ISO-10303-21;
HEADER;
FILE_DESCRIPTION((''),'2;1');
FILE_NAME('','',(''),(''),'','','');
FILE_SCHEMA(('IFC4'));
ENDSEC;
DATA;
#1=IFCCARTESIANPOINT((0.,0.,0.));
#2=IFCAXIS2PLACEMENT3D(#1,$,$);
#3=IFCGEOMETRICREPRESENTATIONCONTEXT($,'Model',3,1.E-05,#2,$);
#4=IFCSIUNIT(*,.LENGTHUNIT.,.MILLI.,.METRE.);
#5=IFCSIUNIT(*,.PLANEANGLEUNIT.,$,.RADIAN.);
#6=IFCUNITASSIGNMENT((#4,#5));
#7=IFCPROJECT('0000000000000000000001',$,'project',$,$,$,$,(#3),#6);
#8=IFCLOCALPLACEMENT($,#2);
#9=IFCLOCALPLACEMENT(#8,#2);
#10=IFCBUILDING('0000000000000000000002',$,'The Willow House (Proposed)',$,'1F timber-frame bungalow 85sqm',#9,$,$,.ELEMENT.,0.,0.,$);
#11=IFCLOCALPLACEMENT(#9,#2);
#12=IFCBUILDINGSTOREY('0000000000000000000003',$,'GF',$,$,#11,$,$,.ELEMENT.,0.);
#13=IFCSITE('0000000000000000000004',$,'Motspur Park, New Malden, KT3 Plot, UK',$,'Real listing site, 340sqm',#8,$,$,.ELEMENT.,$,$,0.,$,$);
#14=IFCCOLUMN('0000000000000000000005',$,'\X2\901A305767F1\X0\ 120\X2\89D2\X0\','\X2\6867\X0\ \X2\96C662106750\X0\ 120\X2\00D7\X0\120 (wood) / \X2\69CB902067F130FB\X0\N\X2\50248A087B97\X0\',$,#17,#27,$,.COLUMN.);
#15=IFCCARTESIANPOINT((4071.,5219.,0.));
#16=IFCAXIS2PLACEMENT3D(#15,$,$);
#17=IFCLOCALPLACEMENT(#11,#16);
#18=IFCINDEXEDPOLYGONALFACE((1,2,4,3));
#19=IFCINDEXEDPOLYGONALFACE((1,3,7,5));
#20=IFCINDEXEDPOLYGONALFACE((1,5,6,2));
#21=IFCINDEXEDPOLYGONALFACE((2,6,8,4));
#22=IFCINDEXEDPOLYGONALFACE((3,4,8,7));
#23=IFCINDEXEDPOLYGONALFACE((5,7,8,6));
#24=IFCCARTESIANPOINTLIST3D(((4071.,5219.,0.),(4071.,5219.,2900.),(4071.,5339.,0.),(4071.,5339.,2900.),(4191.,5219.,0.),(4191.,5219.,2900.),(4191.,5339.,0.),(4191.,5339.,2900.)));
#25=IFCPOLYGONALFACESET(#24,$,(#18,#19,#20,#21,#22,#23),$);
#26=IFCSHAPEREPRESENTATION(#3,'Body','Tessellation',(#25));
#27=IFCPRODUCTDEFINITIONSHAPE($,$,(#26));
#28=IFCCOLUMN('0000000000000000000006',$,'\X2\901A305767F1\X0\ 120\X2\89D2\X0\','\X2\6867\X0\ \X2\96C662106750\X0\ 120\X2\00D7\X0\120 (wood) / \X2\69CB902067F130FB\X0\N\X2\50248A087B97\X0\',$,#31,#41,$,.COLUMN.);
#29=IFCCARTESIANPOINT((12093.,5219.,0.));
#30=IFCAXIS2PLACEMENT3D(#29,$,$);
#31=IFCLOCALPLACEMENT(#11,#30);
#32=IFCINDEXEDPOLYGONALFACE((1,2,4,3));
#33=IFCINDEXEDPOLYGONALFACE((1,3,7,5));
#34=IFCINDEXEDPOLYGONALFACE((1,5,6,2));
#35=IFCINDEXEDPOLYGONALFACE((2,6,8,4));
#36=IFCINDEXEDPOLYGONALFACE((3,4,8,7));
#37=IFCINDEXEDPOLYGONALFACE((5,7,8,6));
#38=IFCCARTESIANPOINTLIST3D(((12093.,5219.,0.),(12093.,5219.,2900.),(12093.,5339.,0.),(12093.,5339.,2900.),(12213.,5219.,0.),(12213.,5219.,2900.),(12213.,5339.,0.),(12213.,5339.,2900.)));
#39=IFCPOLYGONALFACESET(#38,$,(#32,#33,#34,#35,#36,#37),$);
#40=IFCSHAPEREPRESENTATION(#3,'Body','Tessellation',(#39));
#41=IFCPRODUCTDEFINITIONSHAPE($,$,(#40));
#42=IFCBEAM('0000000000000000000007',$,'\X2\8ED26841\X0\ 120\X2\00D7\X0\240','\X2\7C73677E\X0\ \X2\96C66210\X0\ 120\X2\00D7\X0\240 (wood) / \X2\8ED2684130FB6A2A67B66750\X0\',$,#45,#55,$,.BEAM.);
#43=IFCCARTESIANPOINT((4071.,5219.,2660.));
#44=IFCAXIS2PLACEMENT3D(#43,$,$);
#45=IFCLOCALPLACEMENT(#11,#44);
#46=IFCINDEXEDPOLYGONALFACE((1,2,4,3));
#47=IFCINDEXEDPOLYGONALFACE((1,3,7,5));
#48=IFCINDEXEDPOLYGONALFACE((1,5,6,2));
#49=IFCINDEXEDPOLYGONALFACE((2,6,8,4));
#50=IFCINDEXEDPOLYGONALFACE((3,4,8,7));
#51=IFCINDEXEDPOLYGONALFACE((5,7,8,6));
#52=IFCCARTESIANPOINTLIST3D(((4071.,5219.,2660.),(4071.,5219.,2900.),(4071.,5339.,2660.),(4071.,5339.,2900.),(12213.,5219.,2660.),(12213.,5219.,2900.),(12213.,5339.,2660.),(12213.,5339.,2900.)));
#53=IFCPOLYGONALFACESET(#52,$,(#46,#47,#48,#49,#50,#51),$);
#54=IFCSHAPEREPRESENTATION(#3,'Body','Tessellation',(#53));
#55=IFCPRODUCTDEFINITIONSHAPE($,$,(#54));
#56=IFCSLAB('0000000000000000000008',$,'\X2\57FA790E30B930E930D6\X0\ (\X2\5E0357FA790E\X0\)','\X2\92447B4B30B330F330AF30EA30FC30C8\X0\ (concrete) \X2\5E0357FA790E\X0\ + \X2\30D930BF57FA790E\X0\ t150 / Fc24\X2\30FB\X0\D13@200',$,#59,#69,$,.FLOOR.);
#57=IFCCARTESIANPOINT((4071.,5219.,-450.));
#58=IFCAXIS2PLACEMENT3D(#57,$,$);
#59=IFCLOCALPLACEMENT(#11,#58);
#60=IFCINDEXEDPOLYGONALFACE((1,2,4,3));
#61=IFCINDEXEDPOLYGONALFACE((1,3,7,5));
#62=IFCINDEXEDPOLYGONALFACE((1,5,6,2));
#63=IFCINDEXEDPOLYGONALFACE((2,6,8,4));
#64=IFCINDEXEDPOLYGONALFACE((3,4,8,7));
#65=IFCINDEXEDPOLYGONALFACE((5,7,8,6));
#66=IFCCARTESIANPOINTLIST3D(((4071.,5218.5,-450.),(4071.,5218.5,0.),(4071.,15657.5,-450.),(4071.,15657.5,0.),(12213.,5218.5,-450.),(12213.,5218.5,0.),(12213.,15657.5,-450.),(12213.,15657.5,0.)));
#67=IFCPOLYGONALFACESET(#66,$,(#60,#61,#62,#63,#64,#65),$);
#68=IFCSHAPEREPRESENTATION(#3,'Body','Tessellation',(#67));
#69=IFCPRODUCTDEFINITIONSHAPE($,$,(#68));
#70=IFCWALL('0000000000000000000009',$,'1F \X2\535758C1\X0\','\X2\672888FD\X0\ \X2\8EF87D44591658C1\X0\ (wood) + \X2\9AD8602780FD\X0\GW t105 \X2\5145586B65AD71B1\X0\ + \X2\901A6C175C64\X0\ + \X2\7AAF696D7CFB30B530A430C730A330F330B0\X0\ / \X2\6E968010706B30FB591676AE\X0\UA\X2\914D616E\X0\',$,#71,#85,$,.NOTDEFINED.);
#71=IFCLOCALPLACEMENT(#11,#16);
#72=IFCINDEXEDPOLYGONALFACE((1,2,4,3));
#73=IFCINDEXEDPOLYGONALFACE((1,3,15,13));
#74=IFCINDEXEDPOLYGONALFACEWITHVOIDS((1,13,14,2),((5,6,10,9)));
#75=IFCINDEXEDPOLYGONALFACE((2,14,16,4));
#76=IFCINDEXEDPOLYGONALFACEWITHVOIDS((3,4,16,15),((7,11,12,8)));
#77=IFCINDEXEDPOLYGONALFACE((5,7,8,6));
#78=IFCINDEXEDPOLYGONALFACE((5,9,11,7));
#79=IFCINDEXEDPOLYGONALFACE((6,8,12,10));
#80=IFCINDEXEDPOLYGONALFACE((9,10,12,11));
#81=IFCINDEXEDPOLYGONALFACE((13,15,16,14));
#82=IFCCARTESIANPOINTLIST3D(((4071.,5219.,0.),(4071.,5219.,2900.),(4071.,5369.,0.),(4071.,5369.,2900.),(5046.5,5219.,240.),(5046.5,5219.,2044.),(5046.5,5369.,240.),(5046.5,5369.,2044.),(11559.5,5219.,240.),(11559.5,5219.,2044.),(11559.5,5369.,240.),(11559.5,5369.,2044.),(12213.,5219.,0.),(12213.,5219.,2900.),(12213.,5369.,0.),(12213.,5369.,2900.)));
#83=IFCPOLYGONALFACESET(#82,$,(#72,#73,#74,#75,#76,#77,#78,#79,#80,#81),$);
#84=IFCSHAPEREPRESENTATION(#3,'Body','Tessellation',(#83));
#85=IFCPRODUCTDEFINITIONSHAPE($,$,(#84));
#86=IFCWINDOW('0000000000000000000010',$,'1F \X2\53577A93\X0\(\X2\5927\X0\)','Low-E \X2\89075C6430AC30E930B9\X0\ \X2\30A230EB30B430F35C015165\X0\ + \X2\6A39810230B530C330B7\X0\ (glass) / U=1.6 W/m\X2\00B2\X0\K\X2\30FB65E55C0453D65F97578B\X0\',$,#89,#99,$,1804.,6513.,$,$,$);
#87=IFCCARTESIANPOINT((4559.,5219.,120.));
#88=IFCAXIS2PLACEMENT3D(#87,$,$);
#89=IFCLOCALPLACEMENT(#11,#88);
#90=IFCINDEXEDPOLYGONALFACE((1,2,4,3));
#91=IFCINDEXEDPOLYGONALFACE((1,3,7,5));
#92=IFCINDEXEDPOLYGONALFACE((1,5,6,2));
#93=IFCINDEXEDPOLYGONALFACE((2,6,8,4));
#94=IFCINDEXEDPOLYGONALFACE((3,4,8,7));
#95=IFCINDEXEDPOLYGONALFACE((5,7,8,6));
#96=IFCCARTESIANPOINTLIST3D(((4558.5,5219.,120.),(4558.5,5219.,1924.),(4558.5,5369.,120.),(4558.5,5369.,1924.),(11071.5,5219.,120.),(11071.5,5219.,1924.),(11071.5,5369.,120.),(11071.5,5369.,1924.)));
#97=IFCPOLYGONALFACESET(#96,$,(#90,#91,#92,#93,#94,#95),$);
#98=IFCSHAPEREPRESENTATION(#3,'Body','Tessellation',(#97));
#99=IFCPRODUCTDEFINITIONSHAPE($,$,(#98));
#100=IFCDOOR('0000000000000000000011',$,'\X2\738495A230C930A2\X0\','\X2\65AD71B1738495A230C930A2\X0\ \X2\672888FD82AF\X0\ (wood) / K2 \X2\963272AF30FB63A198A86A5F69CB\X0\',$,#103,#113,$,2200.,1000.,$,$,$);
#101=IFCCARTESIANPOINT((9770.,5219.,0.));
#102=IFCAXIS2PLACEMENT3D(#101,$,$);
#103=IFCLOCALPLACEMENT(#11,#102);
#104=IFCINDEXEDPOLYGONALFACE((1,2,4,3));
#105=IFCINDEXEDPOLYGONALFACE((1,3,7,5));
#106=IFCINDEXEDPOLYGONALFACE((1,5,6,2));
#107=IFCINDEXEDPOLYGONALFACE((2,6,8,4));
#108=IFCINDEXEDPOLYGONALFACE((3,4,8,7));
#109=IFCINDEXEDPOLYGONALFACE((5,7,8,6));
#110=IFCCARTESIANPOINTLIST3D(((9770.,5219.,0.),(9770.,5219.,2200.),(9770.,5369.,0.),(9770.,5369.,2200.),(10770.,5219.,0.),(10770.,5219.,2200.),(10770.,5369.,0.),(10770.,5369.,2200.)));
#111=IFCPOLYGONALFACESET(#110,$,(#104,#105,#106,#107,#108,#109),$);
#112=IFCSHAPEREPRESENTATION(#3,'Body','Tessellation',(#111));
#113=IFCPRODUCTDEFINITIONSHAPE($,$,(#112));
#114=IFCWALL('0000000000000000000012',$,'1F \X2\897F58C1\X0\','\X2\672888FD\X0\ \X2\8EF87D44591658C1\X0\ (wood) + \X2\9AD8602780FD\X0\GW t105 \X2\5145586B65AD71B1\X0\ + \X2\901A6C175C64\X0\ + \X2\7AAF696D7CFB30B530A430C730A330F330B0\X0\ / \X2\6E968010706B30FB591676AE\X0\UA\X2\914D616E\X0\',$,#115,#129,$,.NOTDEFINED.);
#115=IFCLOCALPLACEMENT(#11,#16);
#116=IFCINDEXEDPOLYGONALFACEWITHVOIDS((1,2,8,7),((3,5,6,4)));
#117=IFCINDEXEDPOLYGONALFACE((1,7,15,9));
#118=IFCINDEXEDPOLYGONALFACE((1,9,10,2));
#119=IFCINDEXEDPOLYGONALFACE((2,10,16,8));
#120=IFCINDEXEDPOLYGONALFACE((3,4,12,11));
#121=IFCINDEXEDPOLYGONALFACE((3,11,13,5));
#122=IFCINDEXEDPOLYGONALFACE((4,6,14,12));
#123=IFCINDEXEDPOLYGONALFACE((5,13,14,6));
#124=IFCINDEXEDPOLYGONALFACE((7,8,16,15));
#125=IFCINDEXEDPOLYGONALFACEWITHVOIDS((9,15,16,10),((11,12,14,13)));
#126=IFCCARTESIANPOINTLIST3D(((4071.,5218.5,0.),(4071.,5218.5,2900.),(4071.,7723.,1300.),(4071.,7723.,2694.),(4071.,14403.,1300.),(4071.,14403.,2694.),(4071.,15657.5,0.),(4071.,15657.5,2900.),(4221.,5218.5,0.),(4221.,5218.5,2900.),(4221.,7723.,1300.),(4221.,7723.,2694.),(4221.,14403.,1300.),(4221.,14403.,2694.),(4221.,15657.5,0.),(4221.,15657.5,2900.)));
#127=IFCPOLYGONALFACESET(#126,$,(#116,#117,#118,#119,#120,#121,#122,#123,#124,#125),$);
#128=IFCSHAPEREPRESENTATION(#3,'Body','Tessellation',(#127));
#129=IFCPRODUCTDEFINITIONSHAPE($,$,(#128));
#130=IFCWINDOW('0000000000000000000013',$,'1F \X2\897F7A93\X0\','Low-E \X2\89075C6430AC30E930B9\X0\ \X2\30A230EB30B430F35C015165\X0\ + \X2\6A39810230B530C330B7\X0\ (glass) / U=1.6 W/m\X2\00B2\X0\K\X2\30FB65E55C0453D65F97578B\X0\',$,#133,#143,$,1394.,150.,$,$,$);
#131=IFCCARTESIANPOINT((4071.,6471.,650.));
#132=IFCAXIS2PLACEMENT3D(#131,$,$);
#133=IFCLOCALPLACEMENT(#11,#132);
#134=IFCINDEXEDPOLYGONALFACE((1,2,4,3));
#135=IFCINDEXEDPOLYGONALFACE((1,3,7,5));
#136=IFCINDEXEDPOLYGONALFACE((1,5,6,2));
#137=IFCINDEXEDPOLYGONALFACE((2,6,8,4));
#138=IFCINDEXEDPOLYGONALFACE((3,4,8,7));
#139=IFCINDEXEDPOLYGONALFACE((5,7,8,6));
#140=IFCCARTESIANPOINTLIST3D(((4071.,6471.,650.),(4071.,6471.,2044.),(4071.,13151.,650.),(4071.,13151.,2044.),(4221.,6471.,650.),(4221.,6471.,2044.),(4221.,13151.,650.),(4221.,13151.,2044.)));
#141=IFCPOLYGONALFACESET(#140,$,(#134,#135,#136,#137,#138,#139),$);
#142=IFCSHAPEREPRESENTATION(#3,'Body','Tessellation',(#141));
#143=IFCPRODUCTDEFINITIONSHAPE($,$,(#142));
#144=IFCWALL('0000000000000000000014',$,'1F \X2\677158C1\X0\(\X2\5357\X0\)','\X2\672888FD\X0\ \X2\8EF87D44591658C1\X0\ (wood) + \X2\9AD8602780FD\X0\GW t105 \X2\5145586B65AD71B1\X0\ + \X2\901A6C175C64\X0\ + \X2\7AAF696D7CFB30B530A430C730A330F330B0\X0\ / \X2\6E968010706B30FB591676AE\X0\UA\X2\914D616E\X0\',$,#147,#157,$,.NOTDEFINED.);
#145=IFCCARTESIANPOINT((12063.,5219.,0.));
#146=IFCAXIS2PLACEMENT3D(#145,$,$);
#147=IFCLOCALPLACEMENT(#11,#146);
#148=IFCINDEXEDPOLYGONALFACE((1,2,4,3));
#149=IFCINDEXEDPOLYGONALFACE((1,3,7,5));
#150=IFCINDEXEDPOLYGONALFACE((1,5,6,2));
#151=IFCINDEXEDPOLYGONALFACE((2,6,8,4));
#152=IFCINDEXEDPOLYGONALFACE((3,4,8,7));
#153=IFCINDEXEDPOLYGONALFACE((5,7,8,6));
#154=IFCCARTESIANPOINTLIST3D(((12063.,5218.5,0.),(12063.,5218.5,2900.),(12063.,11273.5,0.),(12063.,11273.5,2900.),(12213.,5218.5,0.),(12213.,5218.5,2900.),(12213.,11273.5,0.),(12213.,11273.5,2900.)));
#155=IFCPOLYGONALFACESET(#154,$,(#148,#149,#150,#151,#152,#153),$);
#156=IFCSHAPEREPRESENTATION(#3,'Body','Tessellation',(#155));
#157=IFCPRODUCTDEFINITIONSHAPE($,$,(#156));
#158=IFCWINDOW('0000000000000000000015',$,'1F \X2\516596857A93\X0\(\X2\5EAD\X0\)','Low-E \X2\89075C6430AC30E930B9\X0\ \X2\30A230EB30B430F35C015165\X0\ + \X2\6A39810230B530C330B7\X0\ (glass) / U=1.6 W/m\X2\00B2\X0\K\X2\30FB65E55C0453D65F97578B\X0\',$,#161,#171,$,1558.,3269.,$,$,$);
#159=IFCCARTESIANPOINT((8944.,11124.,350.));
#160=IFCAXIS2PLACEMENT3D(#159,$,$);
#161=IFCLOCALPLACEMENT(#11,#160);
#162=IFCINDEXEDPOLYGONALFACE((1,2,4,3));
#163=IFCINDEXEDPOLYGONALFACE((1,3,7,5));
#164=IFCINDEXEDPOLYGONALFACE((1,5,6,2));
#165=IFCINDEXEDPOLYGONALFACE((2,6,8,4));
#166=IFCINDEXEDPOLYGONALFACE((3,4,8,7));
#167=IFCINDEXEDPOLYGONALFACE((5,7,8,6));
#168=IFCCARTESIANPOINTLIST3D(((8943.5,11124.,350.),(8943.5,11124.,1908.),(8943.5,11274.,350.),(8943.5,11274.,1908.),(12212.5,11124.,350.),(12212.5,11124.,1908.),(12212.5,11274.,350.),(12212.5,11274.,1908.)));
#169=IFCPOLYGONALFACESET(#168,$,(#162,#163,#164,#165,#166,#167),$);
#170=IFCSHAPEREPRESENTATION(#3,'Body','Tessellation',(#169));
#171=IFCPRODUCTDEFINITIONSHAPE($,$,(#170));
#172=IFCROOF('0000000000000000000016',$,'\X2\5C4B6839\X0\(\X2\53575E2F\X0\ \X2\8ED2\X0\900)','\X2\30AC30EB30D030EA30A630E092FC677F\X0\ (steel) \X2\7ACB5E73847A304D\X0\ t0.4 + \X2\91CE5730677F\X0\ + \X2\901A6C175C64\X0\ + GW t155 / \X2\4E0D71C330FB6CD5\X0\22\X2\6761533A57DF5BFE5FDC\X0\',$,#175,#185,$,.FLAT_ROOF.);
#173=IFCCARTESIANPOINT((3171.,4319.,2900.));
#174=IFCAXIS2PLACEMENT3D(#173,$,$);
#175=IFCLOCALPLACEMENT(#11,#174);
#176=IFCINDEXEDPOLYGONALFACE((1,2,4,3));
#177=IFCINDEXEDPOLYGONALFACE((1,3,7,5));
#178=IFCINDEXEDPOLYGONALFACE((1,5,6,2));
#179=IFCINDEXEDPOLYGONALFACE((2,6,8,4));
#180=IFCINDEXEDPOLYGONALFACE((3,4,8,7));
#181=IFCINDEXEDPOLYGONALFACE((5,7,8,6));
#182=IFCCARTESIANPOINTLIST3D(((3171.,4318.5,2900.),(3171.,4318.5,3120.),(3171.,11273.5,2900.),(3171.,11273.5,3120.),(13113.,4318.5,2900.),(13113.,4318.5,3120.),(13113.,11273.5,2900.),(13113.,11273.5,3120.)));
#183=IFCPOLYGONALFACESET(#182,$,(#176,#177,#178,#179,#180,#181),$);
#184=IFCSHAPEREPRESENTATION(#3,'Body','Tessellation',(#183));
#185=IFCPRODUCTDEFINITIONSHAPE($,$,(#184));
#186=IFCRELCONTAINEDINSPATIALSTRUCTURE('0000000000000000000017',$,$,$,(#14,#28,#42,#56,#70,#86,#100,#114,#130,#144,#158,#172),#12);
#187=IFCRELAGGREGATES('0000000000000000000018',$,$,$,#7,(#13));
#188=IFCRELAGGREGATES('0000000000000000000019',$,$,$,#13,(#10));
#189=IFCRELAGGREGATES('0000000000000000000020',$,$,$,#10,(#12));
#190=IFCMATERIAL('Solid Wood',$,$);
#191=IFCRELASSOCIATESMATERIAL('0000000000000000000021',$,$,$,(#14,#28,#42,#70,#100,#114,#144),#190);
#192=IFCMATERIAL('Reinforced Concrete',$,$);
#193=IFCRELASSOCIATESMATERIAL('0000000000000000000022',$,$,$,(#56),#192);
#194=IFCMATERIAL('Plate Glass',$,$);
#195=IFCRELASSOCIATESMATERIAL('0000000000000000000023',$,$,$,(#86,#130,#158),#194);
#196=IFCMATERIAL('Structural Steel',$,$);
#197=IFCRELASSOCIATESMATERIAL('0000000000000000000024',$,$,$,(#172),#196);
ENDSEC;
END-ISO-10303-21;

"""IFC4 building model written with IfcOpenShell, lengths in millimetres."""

from ifc_helpers import new_model, si_unit, frame, frame_2d, origin, place, context, project, spatial, rectangle, extrude, material, element, fill, save


model = new_model("IFC4")

# Units and contexts
model_context = context("Model", 3, precision=1e-05, world=origin())
ifc_project = project(units=[si_unit("LENGTHUNIT", "METRE", prefix="MILLI"), si_unit("PLANEANGLEUNIT", "RADIAN")], contexts=[model_context])

# Site, building, storey
site_placement = place(None, origin())
site = spatial("IfcSite", under=ifc_project, at=site_placement, Name="Motspur Park, New Malden, KT3 Plot, UK", ObjectType="Real listing site, 340sqm", CompositionType="ELEMENT", RefElevation=0.0)
building_placement = place(site_placement, origin())
building = spatial("IfcBuilding", under=site, at=building_placement, Name="The Willow House (Proposed)", ObjectType="1F timber-frame bungalow 85sqm", CompositionType="ELEMENT", ElevationOfRefHeight=0.0, ElevationOfTerrain=0.0)
storey_placement = place(building_placement, origin())
storey = spatial("IfcBuildingStorey", under=building, at=storey_placement, Name="GF", CompositionType="ELEMENT", Elevation=0.0)

# Columns
ifc_material_1 = material(Name="Solid Wood")
column_1_placement = place(storey_placement, frame((4071.0, 5219.0, 0.0)))
element("IfcColumn", 1, at=column_1_placement, inside=storey, material=ifc_material_1, Name="通し柱 120角", Description="桧 集成材 120×120 (wood) / 構造柱・N値計算", PredefinedType="COLUMN", context=model_context, shape_type="SweptSolid", body=[
    extrude(rectangle(XDim=120.0, YDim=120.0, at=frame_2d((60.0, 60.0))), frame((4071.0, 5219.0, 0.0)), (0.0, 0.0, 1.0), 2900.0),
])
column_2_placement = place(storey_placement, frame((12093.0, 5219.0, 0.0)))
element("IfcColumn", 2, at=column_2_placement, inside=storey, material=ifc_material_1, Name="通し柱 120角", Description="桧 集成材 120×120 (wood) / 構造柱・N値計算", PredefinedType="COLUMN", context=model_context, shape_type="SweptSolid", body=[
    extrude(rectangle(XDim=120.0, YDim=120.0, at=frame_2d((60.0, 60.0))), frame((12093.0, 5219.0, 0.0)), (0.0, 0.0, 1.0), 2900.0),
])

# Beam
beam_1_placement = place(storey_placement, frame((4071.0, 5219.0, 2660.0)))
element("IfcBeam", 3, at=beam_1_placement, inside=storey, material=ifc_material_1, Name="軒桁 120×240", Description="米松 集成 120×240 (wood) / 軒桁・横架材", PredefinedType="BEAM", context=model_context, shape_type="SweptSolid", body=[
    extrude(rectangle(XDim=8142.0, YDim=120.0, at=frame_2d((4071.0, 60.0))), frame((4071.0, 5219.0, 2660.0)), (0.0, 0.0, 1.0), 240.0),
])

# Slab
ifc_material_2 = material(Name="Reinforced Concrete")
slab_1_placement = place(storey_placement, frame((4071.0, 5219.0, -450.0)))
element("IfcSlab", 4, at=slab_1_placement, inside=storey, material=ifc_material_2, Name="基礎スラブ (布基礎)", Description="鉄筋コンクリート (concrete) 布基礎 + ベタ基礎 t150 / Fc24・D13@200", PredefinedType="FLOOR", context=model_context, shape_type="SweptSolid", body=[
    extrude(rectangle(XDim=8142.0, YDim=10439.0, at=frame_2d((4071.0, 5219.0))), frame((4071.0, 5219.0, -450.0)), (0.0, 0.0, 1.0), 450.0),
])

# Wall, openings, window, door
wall_1_placement = place(storey_placement, frame((4071.0, 5219.0, 0.0)))
wall_1 = element("IfcWall", 5, at=wall_1_placement, inside=storey, material=ifc_material_1, Name="1F 南壁", Description="木製 軸組外壁 (wood) + 高性能GW t105 充填断熱 + 通気層 + 窯業系サイディング / 準耐火・外皮UA配慮", PredefinedType="NOTDEFINED", context=model_context, shape_type="SweptSolid", body=[
    extrude(rectangle(XDim=8142.0, YDim=150.0, at=frame_2d((4071.0, 75.0))), frame((4071.0, 5219.0, 0.0)), (0.0, 0.0, 1.0), 2900.0),
])
opening_1_placement = place(storey_placement, frame((4559.0, 5219.0, 120.0)))
opening_1 = element("IfcOpeningElement", 6, at=opening_1_placement, cuts=wall_1, PredefinedType="NOTDEFINED", context=model_context, shape_type="SweptSolid", body=[
    extrude(rectangle(XDim=6513.0, YDim=150.0, at=frame_2d((3256.0, 75.0))), frame((4559.0, 5219.0, 120.0)), (0.0, 0.0, 1.0), 1804.0),
])
opening_2_placement = place(storey_placement, frame((9770.0, 5219.0, 0.0)))
opening_2 = element("IfcOpeningElement", 7, at=opening_2_placement, cuts=wall_1, PredefinedType="NOTDEFINED", context=model_context, shape_type="SweptSolid", body=[
    extrude(rectangle(XDim=1000.0, YDim=150.0, at=frame_2d((500.0, 75.0))), frame((9770.0, 5219.0, 0.0)), (0.0, 0.0, 1.0), 2200.0),
])
ifc_material_3 = material(Name="Plate Glass")
window_1_placement = place(storey_placement, frame((4559.0, 5219.0, 120.0)))
window_1 = element("IfcWindow", 8, at=window_1_placement, inside=storey, material=ifc_material_3, Name="1F 南窓(大)", Description="Low-E 複層ガラス アルゴン封入 + 樹脂サッシ (glass) / U=1.6 W/m²K・日射取得型", OverallHeight=1804.0, OverallWidth=6513.0, context=model_context, shape_type="SweptSolid", body=[
    extrude(rectangle(XDim=6513.0, YDim=150.0, at=frame_2d((3256.0, 75.0))), frame((4559.0, 5219.0, 120.0)), (0.0, 0.0, 1.0), 1804.0),
])
fill(opening_1, window_1)
door_1_placement = place(storey_placement, frame((9770.0, 5219.0, 0.0)))
door_1 = element("IfcDoor", 9, at=door_1_placement, inside=storey, material=ifc_material_1, Name="玄関ドア", Description="断熱玄関ドア 木製芯 (wood) / K2 防犯・採風機構", OverallHeight=2200.0, OverallWidth=1000.0, context=model_context, shape_type="SweptSolid", body=[
    extrude(rectangle(XDim=1000.0, YDim=150.0, at=frame_2d((500.0, 75.0))), frame((9770.0, 5219.0, 0.0)), (0.0, 0.0, 1.0), 2200.0),
])
fill(opening_2, door_1)

# Walls, openings, windows
wall_2_placement = place(storey_placement, frame((4071.0, 5219.0, 0.0)))
wall_2 = element("IfcWall", 10, at=wall_2_placement, inside=storey, material=ifc_material_1, Name="1F 西壁", Description="木製 軸組外壁 (wood) + 高性能GW t105 充填断熱 + 通気層 + 窯業系サイディング / 準耐火・外皮UA配慮", PredefinedType="NOTDEFINED", context=model_context, shape_type="SweptSolid", body=[
    extrude(rectangle(XDim=150.0, YDim=10439.0, at=frame_2d((75.0, 5219.0))), frame((4071.0, 5219.0, 0.0)), (0.0, 0.0, 1.0), 2900.0),
])
opening_3_placement = place(storey_placement, frame((4071.0, 6471.0, 650.0)))
opening_3 = element("IfcOpeningElement", 11, at=opening_3_placement, cuts=wall_2, PredefinedType="NOTDEFINED", context=model_context, shape_type="SweptSolid", body=[
    extrude(rectangle(XDim=150.0, YDim=6680.0, at=frame_2d((75.0, 3340.0))), frame((4071.0, 6471.0, 650.0)), (0.0, 0.0, 1.0), 1394.0),
])
window_2_placement = place(storey_placement, frame((4071.0, 6471.0, 650.0)))
window_2 = element("IfcWindow", 12, at=window_2_placement, inside=storey, material=ifc_material_3, Name="1F 西窓", Description="Low-E 複層ガラス アルゴン封入 + 樹脂サッシ (glass) / U=1.6 W/m²K・日射取得型", OverallHeight=1394.0, OverallWidth=150.0, context=model_context, shape_type="SweptSolid", body=[
    extrude(rectangle(XDim=150.0, YDim=6680.0, at=frame_2d((75.0, 3340.0))), frame((4071.0, 6471.0, 650.0)), (0.0, 0.0, 1.0), 1394.0),
])
fill(opening_3, window_2)
wall_3_placement = place(storey_placement, frame((12063.0, 5219.0, 0.0)))
wall_3 = element("IfcWall", 13, at=wall_3_placement, inside=storey, material=ifc_material_1, Name="1F 東壁(南)", Description="木製 軸組外壁 (wood) + 高性能GW t105 充填断熱 + 通気層 + 窯業系サイディング / 準耐火・外皮UA配慮", PredefinedType="NOTDEFINED", context=model_context, shape_type="SweptSolid", body=[
    extrude(rectangle(XDim=150.0, YDim=6055.0, at=frame_2d((75.0, 3027.0))), frame((12063.0, 5219.0, 0.0)), (0.0, 0.0, 1.0), 2900.0),
])
opening_4_placement = place(storey_placement, frame((8944.0, 11124.0, 350.0)))
opening_4 = element("IfcOpeningElement", 14, at=opening_4_placement, cuts=wall_3, PredefinedType="NOTDEFINED", context=model_context, shape_type="SweptSolid", body=[
    extrude(rectangle(XDim=3269.0, YDim=150.0, at=frame_2d((1634.0, 75.0))), frame((8944.0, 11124.0, 350.0)), (0.0, 0.0, 1.0), 1558.0),
])
window_3_placement = place(storey_placement, frame((8944.0, 11124.0, 350.0)))
window_3 = element("IfcWindow", 15, at=window_3_placement, inside=storey, material=ifc_material_3, Name="1F 入隅窓(庭)", Description="Low-E 複層ガラス アルゴン封入 + 樹脂サッシ (glass) / U=1.6 W/m²K・日射取得型", OverallHeight=1558.0, OverallWidth=3269.0, context=model_context, shape_type="SweptSolid", body=[
    extrude(rectangle(XDim=3269.0, YDim=150.0, at=frame_2d((1634.0, 75.0))), frame((8944.0, 11124.0, 350.0)), (0.0, 0.0, 1.0), 1558.0),
])
fill(opening_4, window_3)

# Roof
ifc_material_4 = material(Name="Structural Steel")
roof_placement = place(storey_placement, frame((3171.0, 4319.0, 2900.0)))
element("IfcRoof", 16, at=roof_placement, inside=storey, material=ifc_material_4, Name="屋根(南帯 軒900)", Description="ガルバリウム鋼板 (steel) 立平葺き t0.4 + 野地板 + 通気層 + GW t155 / 不燃・法22条区域対応", PredefinedType="FLAT_ROOF", context=model_context, shape_type="SweptSolid", body=[
    extrude(rectangle(XDim=9942.0, YDim=6955.0, at=frame_2d((4971.0, 3477.0))), frame((3171.0, 4319.0, 2900.0)), (0.0, 0.0, 1.0), 220.0),
])

save(model, "model.ifc")
